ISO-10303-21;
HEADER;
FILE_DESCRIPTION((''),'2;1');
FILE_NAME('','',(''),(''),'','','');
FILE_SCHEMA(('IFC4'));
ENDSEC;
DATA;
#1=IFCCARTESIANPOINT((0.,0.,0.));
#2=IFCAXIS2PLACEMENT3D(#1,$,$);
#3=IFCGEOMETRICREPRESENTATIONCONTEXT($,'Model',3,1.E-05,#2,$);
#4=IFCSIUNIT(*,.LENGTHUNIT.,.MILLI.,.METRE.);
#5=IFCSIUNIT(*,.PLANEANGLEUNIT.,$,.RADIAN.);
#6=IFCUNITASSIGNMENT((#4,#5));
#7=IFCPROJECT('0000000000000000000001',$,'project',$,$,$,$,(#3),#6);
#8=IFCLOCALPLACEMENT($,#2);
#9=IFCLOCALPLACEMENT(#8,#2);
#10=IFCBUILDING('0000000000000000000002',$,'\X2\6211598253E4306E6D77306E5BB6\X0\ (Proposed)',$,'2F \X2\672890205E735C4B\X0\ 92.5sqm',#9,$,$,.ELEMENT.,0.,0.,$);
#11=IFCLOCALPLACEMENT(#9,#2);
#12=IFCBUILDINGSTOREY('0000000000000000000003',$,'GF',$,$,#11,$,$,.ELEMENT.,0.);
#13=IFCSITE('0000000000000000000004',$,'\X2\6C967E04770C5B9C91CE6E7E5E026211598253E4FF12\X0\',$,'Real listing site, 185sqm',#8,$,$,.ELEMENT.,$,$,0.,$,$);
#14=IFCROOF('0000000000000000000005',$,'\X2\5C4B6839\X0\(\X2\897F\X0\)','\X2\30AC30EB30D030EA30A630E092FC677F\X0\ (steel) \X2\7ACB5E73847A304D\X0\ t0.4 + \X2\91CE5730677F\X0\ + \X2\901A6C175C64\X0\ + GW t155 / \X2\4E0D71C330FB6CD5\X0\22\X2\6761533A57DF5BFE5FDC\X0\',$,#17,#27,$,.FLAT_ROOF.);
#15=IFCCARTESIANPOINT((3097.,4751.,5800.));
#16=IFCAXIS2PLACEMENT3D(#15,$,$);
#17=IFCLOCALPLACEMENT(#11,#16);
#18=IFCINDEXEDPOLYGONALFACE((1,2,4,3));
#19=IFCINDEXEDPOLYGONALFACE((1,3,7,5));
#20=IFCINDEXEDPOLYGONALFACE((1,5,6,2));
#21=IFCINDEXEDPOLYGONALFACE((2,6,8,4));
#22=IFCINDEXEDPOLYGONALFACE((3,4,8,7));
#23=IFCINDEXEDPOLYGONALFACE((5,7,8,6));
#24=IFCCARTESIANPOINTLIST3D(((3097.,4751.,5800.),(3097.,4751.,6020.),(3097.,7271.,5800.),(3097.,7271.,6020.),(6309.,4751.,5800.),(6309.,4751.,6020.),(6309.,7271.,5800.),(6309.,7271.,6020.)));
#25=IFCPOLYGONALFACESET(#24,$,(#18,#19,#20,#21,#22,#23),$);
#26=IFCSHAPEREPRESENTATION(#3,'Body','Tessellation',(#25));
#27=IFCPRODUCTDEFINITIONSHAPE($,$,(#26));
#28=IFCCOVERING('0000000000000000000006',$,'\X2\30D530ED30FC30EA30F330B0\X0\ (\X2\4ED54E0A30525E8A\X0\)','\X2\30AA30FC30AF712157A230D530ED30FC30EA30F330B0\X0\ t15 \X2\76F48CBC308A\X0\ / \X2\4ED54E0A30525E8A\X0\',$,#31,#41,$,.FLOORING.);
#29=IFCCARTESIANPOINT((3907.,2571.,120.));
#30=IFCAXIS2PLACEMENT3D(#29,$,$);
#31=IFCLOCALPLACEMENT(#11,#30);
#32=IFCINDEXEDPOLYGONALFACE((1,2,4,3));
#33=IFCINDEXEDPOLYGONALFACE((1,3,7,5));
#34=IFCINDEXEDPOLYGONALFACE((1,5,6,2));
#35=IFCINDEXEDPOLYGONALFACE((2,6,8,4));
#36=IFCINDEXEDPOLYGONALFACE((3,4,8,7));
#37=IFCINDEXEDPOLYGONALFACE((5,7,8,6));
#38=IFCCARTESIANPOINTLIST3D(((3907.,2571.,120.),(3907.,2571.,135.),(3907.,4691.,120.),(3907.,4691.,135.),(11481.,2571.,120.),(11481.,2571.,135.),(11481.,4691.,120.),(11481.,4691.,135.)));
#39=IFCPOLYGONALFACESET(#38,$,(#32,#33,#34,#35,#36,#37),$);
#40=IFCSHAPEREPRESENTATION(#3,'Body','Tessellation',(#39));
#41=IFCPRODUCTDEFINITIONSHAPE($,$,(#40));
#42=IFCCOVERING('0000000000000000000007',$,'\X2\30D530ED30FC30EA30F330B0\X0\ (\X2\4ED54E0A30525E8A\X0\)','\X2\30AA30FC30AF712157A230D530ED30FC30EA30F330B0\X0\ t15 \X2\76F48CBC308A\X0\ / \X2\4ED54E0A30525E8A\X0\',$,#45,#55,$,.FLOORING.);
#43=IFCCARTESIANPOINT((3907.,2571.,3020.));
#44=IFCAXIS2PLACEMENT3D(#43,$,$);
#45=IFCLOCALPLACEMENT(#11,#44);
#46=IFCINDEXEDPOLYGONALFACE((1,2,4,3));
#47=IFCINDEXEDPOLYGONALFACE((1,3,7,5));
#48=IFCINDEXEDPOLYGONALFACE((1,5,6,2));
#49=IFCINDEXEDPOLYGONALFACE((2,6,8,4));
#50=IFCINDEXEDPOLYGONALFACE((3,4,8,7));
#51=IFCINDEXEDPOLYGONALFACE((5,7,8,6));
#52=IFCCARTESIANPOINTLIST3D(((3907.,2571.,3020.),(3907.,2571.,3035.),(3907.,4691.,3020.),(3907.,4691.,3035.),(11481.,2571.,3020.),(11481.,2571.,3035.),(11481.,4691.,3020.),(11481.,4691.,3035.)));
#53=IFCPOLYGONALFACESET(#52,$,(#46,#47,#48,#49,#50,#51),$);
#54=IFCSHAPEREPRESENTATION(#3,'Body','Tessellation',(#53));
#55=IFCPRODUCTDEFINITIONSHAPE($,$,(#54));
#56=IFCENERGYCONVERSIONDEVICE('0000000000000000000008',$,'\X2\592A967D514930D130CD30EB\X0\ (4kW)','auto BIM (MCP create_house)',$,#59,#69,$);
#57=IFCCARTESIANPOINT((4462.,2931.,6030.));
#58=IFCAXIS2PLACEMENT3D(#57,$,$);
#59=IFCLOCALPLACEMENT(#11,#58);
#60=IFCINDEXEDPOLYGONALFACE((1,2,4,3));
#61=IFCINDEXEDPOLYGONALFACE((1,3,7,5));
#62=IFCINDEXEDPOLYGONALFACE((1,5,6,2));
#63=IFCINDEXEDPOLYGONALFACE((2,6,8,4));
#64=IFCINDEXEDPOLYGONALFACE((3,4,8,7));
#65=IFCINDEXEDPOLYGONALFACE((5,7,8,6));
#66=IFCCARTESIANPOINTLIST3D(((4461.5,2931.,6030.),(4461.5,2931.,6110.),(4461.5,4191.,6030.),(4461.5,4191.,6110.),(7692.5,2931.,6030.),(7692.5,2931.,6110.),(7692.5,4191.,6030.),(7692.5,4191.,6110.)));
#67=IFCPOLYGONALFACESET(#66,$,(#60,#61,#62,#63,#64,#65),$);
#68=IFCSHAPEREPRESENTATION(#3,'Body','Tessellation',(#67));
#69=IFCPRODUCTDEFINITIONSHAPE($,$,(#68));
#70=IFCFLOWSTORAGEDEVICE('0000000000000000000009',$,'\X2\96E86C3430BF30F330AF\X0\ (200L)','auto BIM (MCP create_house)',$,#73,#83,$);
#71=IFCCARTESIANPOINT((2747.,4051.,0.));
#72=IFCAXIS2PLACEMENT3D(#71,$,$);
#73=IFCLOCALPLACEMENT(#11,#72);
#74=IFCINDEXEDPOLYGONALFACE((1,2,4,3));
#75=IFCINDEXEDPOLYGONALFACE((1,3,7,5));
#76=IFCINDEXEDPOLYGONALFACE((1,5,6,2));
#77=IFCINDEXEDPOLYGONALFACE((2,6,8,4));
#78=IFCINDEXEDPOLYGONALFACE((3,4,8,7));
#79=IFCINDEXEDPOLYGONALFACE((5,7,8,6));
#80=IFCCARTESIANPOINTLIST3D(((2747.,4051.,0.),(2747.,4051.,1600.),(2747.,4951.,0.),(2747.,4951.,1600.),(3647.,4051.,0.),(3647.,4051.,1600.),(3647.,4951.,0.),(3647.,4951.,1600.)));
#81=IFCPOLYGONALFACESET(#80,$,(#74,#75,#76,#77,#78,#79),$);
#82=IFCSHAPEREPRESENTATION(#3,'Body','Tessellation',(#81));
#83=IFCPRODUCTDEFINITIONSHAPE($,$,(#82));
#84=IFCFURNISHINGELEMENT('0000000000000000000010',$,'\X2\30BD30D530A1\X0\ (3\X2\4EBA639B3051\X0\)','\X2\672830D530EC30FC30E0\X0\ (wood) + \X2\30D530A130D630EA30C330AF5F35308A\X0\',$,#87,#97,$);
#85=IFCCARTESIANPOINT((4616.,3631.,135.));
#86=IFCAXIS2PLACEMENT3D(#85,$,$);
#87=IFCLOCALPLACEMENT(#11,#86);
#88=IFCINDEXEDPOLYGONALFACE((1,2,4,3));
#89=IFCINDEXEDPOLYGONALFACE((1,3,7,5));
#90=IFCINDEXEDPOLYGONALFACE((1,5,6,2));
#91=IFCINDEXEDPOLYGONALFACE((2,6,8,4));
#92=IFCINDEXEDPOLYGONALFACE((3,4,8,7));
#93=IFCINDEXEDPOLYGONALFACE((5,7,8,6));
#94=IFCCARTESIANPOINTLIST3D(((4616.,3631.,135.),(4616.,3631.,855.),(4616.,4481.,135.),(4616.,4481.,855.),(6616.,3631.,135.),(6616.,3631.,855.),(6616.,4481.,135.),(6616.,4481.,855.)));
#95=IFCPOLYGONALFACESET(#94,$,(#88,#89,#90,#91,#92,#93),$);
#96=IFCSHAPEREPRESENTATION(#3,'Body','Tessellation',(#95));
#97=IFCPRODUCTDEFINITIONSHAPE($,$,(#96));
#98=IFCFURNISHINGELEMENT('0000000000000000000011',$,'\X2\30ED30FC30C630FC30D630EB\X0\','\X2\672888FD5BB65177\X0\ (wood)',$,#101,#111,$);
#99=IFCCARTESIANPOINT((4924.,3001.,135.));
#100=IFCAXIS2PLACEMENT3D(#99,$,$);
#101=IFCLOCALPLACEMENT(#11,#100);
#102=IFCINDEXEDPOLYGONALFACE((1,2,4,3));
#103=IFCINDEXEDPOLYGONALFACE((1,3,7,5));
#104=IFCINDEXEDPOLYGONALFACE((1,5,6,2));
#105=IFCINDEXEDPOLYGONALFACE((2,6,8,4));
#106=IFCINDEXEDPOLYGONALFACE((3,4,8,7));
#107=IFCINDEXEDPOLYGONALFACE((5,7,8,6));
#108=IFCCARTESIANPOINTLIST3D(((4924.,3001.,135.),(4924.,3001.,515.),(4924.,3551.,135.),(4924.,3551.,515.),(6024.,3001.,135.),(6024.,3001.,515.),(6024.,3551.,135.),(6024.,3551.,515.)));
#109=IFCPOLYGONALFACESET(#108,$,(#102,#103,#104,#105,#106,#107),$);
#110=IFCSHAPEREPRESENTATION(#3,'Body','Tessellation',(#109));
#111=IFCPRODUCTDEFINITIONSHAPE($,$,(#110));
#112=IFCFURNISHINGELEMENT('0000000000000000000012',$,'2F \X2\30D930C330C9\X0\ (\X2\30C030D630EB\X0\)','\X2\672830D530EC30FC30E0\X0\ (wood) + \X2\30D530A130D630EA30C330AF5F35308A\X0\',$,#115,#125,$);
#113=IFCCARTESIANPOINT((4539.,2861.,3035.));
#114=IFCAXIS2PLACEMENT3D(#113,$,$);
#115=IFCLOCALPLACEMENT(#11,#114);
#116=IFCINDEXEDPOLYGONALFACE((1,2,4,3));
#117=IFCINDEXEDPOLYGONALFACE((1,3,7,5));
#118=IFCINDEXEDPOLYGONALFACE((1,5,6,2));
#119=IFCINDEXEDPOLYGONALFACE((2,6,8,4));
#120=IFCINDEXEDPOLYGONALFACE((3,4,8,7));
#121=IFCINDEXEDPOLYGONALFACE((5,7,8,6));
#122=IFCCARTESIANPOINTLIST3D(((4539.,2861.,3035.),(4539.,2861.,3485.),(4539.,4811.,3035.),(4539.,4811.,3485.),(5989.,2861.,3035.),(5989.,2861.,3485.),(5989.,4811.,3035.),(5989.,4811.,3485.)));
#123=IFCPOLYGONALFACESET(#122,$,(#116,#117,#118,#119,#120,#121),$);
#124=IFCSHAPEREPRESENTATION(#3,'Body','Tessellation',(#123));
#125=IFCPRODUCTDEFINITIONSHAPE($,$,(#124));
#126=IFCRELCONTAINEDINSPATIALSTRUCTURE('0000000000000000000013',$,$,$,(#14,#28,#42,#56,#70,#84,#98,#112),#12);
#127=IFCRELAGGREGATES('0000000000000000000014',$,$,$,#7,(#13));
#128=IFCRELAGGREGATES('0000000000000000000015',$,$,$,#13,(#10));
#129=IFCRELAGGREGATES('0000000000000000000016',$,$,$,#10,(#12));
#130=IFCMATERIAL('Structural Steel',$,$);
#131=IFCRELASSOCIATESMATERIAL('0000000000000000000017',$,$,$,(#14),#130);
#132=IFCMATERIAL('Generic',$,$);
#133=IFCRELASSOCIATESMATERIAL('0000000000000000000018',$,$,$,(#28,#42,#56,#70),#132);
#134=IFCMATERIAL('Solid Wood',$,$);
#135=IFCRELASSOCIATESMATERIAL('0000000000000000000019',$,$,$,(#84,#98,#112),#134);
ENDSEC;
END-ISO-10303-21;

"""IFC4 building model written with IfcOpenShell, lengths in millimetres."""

from ifc_helpers import new_model, si_unit, frame, frame_2d, origin, place, context, project, spatial, rectangle, extrude, material, element, save


model = new_model("IFC4")

# Units and contexts
model_context = context("Model", 3, precision=1e-05, world=origin())
ifc_project = project(units=[si_unit("LENGTHUNIT", "METRE", prefix="MILLI"), si_unit("PLANEANGLEUNIT", "RADIAN")], contexts=[model_context])

# Site, building, storey
site_placement = place(None, origin())
site = spatial("IfcSite", under=ifc_project, at=site_placement, Name="沖縄県宜野湾市我如古２", ObjectType="Real listing site, 185sqm", CompositionType="ELEMENT", RefElevation=0.0)
building_placement = place(site_placement, origin())
building = spatial("IfcBuilding", under=site, at=building_placement, Name="我如古の海の家 (Proposed)", ObjectType="2F 木造平屋 92.5sqm", CompositionType="ELEMENT", ElevationOfRefHeight=0.0, ElevationOfTerrain=0.0)
storey_placement = place(building_placement, origin())
storey = spatial("IfcBuildingStorey", under=building, at=storey_placement, Name="GF", CompositionType="ELEMENT", Elevation=0.0)

# Shared definitions
ifc_material_1 = material(Name="Solid Wood")

# Roof
ifc_material_2 = material(Name="Structural Steel")
roof_1_placement = place(storey_placement, frame((3097.0, 4751.0, 5800.0)))
element("IfcRoof", 1, at=roof_1_placement, inside=storey, material=ifc_material_2, Name="屋根(西)", Description="ガルバリウム鋼板 (steel) 立平葺き t0.4 + 野地板 + 通気層 + GW t155 / 不燃・法22条区域対応", PredefinedType="FLAT_ROOF", context=model_context, shape_type="SweptSolid", body=[
    extrude(rectangle(XDim=3212.0, YDim=2520.0, at=frame_2d((1606.0, 1260.0))), frame((3097.0, 4751.0, 5800.0)), (0.0, 0.0, 1.0), 220.0),
])

# Coverings
ifc_material_3 = material(Name="Generic")
covering_1_placement = place(storey_placement, frame((3907.0, 2571.0, 120.0)))
element("IfcCovering", 2, at=covering_1_placement, inside=storey, material=ifc_material_3, Name="フローリング (仕上げ床)", Description="オーク無垢フローリング t15 直貼り / 仕上げ床", PredefinedType="FLOORING", context=model_context, shape_type="SweptSolid", body=[
    extrude(rectangle(XDim=7574.0, YDim=2120.0, at=frame_2d((3787.0, 1060.0))), frame((3907.0, 2571.0, 120.0)), (0.0, 0.0, 1.0), 15.0),
])
covering_2_placement = place(storey_placement, frame((3907.0, 2571.0, 3020.0)))
element("IfcCovering", 3, at=covering_2_placement, inside=storey, material=ifc_material_3, Name="フローリング (仕上げ床)", Description="オーク無垢フローリング t15 直貼り / 仕上げ床", PredefinedType="FLOORING", context=model_context, shape_type="SweptSolid", body=[
    extrude(rectangle(XDim=7574.0, YDim=2120.0, at=frame_2d((3787.0, 1060.0))), frame((3907.0, 2571.0, 3020.0)), (0.0, 0.0, 1.0), 15.0),
])

# Energy conversion device
energy_conversion_device_placement = place(storey_placement, frame((4462.0, 2931.0, 6030.0)))
element("IfcEnergyConversionDevice", 4, at=energy_conversion_device_placement, inside=storey, material=ifc_material_3, Name="太陽光パネル (4kW)", Description="auto BIM (MCP create_house)", context=model_context, shape_type="SweptSolid", body=[
    extrude(rectangle(XDim=3231.0, YDim=1260.0, at=frame_2d((1615.0, 630.0))), frame((4462.0, 2931.0, 6030.0)), (0.0, 0.0, 1.0), 80.0),
])

# Flow storage device
flow_storage_device_placement = place(storey_placement, frame((2747.0, 4051.0, 0.0)))
element("IfcFlowStorageDevice", 5, at=flow_storage_device_placement, inside=storey, material=ifc_material_3, Name="雨水タンク (200L)", Description="auto BIM (MCP create_house)", context=model_context, shape_type="SweptSolid", body=[
    extrude(rectangle(XDim=900.0, YDim=900.0, at=frame_2d((450.0, 450.0))), frame((2747.0, 4051.0, 0.0)), (0.0, 0.0, 1.0), 1600.0),
])

# Furnishing elements
furnishing_1_placement = place(storey_placement, frame((4616.0, 3631.0, 135.0)))
element("IfcFurnishingElement", 6, at=furnishing_1_placement, inside=storey, material=ifc_material_1, Name="ソファ (3人掛け)", Description="木フレーム (wood) + ファブリック張り", context=model_context, shape_type="SweptSolid", body=[
    extrude(rectangle(XDim=2000.0, YDim=850.0, at=frame_2d((1000.0, 425.0))), frame((4616.0, 3631.0, 135.0)), (0.0, 0.0, 1.0), 720.0),
])
furnishing_2_placement = place(storey_placement, frame((4924.0, 3001.0, 135.0)))
element("IfcFurnishingElement", 7, at=furnishing_2_placement, inside=storey, material=ifc_material_1, Name="ローテーブル", Description="木製家具 (wood)", context=model_context, shape_type="SweptSolid", body=[
    extrude(rectangle(XDim=1100.0, YDim=550.0, at=frame_2d((550.0, 275.0))), frame((4924.0, 3001.0, 135.0)), (0.0, 0.0, 1.0), 380.0),
])
furnishing_3_placement = place(storey_placement, frame((4539.0, 2861.0, 3035.0)))
element("IfcFurnishingElement", 8, at=furnishing_3_placement, inside=storey, material=ifc_material_1, Name="2F ベッド (ダブル)", Description="木フレーム (wood) + ファブリック張り", context=model_context, shape_type="SweptSolid", body=[
    extrude(rectangle(XDim=1450.0, YDim=1950.0, at=frame_2d((725.0, 975.0))), frame((4539.0, 2861.0, 3035.0)), (0.0, 0.0, 1.0), 450.0),
])

save(model, "model.ifc")
